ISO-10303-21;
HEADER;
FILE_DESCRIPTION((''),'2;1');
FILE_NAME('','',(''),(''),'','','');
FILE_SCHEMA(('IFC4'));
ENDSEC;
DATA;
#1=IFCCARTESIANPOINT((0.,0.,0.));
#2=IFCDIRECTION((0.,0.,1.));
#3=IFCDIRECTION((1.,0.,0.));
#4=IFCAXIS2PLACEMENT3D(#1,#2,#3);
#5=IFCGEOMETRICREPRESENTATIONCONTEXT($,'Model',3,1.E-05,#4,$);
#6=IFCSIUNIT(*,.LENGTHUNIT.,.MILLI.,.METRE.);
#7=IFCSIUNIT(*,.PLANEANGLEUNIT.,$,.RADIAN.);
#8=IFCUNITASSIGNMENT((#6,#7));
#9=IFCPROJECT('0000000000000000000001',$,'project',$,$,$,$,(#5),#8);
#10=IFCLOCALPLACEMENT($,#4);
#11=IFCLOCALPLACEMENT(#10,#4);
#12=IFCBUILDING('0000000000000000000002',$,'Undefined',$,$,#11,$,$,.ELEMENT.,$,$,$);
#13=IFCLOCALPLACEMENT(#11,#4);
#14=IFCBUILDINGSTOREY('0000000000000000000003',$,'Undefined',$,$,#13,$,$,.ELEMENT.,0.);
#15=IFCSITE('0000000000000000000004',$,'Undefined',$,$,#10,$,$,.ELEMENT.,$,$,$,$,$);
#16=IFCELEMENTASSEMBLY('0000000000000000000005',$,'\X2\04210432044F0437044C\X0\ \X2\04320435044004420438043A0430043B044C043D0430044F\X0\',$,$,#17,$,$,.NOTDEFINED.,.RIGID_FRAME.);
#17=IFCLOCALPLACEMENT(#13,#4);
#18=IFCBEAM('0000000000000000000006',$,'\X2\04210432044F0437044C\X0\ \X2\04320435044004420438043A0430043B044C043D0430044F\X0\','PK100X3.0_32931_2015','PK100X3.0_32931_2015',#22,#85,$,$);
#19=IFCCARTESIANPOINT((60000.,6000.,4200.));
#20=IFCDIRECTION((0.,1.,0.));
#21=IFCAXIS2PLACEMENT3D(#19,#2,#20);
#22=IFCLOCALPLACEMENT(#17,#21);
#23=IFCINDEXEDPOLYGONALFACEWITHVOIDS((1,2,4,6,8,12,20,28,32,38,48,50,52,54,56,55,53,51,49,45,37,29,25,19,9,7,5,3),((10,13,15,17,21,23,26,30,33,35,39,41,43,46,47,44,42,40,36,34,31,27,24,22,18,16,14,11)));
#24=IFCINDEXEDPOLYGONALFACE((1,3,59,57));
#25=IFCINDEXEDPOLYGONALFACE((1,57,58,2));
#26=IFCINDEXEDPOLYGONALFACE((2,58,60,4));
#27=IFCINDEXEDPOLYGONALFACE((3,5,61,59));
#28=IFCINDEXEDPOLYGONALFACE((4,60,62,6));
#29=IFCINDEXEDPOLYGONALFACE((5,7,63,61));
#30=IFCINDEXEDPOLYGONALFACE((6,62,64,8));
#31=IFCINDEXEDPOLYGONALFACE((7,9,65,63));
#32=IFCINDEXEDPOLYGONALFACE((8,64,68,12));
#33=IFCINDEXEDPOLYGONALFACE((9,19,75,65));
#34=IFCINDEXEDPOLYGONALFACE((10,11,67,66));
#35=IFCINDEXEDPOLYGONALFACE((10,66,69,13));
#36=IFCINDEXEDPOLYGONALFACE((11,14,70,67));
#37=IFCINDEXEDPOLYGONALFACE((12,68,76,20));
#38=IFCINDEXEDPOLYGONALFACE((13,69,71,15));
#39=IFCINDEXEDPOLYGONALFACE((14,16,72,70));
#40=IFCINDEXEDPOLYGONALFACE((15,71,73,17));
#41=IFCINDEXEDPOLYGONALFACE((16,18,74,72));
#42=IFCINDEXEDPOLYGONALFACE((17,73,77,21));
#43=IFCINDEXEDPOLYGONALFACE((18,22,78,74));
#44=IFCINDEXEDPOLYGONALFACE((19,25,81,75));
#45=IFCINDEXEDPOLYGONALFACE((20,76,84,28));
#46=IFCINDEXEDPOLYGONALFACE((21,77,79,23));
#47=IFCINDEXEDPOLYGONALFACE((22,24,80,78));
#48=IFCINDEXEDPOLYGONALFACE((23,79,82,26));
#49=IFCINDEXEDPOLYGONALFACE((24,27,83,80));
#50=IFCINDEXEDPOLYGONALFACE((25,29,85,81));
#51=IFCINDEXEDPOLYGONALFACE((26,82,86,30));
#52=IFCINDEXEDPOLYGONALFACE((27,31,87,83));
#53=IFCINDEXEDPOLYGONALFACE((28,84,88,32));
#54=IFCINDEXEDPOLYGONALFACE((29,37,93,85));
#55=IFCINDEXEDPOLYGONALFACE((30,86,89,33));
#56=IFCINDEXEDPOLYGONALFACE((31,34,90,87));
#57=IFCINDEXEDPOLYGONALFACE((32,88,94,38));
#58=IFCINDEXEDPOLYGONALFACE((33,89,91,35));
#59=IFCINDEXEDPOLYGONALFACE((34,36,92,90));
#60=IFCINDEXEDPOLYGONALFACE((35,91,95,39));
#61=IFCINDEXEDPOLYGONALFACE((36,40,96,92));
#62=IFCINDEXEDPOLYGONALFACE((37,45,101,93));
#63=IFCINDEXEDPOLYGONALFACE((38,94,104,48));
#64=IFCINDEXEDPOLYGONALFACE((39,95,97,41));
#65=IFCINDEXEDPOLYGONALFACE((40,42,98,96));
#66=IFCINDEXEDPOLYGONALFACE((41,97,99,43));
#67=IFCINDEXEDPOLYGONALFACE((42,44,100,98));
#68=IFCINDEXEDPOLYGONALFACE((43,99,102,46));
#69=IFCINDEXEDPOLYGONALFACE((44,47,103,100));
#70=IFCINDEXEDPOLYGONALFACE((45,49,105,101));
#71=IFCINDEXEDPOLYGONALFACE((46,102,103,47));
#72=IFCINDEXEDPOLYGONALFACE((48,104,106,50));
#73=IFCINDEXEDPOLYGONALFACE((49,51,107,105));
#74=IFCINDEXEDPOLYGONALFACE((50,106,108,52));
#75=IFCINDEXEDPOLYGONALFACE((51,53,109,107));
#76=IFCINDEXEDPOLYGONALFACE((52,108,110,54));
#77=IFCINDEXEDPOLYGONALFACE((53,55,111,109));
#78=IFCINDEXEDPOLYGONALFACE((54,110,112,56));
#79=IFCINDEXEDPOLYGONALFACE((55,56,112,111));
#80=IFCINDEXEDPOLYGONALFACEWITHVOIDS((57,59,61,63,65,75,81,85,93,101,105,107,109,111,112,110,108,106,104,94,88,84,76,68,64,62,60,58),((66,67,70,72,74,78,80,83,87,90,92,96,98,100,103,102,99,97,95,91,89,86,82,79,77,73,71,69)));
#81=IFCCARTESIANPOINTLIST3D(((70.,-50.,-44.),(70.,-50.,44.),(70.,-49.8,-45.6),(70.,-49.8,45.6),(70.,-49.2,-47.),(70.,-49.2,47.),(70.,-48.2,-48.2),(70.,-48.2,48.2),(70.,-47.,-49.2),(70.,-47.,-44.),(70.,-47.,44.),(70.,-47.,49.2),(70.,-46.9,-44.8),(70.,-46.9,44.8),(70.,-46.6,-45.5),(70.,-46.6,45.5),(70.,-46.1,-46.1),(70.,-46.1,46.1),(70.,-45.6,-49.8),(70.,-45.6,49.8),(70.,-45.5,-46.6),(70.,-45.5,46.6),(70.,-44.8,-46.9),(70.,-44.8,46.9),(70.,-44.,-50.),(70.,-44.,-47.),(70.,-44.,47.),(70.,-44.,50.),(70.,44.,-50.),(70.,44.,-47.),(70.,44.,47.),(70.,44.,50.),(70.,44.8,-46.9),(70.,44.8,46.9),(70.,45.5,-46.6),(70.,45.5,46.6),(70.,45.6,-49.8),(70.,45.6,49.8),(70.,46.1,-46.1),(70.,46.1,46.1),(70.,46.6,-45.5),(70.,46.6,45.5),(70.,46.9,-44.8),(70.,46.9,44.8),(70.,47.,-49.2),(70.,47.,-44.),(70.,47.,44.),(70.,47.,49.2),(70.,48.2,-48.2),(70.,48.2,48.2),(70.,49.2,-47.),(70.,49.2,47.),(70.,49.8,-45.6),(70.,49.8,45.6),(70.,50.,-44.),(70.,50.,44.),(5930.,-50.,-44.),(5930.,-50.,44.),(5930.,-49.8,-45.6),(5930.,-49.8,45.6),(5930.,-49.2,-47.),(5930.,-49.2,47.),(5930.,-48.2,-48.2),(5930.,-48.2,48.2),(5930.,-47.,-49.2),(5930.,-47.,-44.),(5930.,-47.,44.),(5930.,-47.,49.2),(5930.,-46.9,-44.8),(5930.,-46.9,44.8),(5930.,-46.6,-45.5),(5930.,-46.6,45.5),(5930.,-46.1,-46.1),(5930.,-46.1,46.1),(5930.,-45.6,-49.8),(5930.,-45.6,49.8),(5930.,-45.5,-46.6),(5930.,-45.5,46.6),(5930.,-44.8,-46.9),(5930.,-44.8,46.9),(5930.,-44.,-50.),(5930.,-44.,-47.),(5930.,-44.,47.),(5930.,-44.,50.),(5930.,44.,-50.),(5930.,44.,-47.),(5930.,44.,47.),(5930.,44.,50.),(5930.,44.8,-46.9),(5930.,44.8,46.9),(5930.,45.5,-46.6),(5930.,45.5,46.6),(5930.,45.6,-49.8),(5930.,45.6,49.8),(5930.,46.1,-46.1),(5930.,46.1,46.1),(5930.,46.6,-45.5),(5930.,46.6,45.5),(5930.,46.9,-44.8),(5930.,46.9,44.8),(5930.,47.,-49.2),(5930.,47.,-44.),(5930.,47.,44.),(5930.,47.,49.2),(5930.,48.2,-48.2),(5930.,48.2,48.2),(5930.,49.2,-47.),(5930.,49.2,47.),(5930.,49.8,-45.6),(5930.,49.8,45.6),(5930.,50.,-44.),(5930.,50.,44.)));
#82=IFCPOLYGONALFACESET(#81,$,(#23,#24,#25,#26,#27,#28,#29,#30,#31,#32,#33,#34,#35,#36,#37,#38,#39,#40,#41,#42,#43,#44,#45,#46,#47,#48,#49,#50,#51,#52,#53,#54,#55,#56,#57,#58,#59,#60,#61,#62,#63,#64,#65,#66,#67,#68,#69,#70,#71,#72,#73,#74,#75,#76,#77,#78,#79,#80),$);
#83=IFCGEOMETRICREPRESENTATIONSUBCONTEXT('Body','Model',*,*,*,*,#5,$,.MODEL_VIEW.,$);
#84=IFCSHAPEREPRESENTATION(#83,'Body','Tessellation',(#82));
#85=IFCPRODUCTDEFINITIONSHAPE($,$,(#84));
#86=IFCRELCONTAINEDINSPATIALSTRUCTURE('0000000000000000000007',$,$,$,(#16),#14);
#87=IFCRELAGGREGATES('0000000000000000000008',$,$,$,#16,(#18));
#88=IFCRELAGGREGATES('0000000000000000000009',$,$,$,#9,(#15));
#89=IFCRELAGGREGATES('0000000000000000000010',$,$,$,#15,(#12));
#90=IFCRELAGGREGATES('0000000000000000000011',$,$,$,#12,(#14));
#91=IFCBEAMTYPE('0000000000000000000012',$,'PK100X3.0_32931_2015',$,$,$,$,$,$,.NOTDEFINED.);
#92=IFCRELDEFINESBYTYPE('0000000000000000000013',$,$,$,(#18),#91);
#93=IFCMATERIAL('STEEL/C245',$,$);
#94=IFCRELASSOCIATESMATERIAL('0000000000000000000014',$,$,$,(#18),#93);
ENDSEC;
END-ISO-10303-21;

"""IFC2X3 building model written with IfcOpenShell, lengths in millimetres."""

from ifc_helpers import new_model, si_unit, frame, origin_with_axes, origin_2d_with_axis, place, context, subcontext, project, spatial, hollow_rectangle, extrude, clip, halfspace, material, type_object, element, aggregate, save


model = new_model("IFC2X3")

# Units and contexts
model_context = context("Model", 3, precision=1e-05, world=origin_with_axes())
body_context = subcontext(model_context, "Body", "Model", "MODEL_VIEW")
ifc_project = project(units=[si_unit("LENGTHUNIT", "METRE", prefix="MILLI"), si_unit("PLANEANGLEUNIT", "RADIAN")], contexts=[model_context])

# Site, building, storey
site_placement = place(None, origin_with_axes())
site = spatial("IfcSite", under=ifc_project, at=site_placement, Name="Undefined", CompositionType="ELEMENT")
building_placement = place(site_placement, origin_with_axes())
building = spatial("IfcBuilding", under=site, at=building_placement, Name="Undefined", CompositionType="ELEMENT")
storey_placement = place(building_placement, origin_with_axes())
storey = spatial("IfcBuildingStorey", under=building, at=storey_placement, Name="Undefined", CompositionType="ELEMENT", Elevation=0.0)

# Element assembly, beam
assembly_1_placement = place(storey_placement, origin_with_axes())
assembly_1 = element("IfcElementAssembly", 1, at=assembly_1_placement, inside=storey, Name="Связь вертикальная", AssemblyPlace="NOTDEFINED", PredefinedType="RIGID_FRAME")
ifc_material_1 = material(Name="STEEL/C245")
beam_type_1 = type_object("IfcBeamType", Name="PK100X3.0_32931_2015", PredefinedType="NOTDEFINED")
beam_1_placement = place(assembly_1_placement, frame((60000.0, 6000.0, 4200.0), z_axis=(0.0, 0.0, 1.0), x_axis=(0.0, 1.0, 0.0)))
beam_1 = element("IfcBeam", 2, at=beam_1_placement, type_object=beam_type_1, material=ifc_material_1, Name="Связь вертикальная", Description="PK100X3.0_32931_2015", ObjectType="PK100X3.0_32931_2015", context=body_context, shape_type="Clipping", body=[
    clip(clip(extrude(hollow_rectangle(XDim=100.0, YDim=100.0, WallThickness=3.0, InnerFilletRadius=3.0, OuterFilletRadius=6.0, at=origin_2d_with_axis()), frame((5930.0, 0.0, 0.0), z_axis=(-1.0, 0.0, 0.0), x_axis=(0.0, -1.0, 0.0)), (0.0, 0.0, 1.0), 5860.0), halfspace(frame((5930.0, 0.0, -164.1), z_axis=(-1.0, 0.0, 0.0), x_axis=(0.0, 1.0, 0.0)), True)), halfspace(frame((70.0, 0.0, 380.8), z_axis=(-1.0, 0.0, 0.0), x_axis=(0.0, 1.0, 0.0)), False)),
])
aggregate(assembly_1, [beam_1])

save(model, "model.ifc")
